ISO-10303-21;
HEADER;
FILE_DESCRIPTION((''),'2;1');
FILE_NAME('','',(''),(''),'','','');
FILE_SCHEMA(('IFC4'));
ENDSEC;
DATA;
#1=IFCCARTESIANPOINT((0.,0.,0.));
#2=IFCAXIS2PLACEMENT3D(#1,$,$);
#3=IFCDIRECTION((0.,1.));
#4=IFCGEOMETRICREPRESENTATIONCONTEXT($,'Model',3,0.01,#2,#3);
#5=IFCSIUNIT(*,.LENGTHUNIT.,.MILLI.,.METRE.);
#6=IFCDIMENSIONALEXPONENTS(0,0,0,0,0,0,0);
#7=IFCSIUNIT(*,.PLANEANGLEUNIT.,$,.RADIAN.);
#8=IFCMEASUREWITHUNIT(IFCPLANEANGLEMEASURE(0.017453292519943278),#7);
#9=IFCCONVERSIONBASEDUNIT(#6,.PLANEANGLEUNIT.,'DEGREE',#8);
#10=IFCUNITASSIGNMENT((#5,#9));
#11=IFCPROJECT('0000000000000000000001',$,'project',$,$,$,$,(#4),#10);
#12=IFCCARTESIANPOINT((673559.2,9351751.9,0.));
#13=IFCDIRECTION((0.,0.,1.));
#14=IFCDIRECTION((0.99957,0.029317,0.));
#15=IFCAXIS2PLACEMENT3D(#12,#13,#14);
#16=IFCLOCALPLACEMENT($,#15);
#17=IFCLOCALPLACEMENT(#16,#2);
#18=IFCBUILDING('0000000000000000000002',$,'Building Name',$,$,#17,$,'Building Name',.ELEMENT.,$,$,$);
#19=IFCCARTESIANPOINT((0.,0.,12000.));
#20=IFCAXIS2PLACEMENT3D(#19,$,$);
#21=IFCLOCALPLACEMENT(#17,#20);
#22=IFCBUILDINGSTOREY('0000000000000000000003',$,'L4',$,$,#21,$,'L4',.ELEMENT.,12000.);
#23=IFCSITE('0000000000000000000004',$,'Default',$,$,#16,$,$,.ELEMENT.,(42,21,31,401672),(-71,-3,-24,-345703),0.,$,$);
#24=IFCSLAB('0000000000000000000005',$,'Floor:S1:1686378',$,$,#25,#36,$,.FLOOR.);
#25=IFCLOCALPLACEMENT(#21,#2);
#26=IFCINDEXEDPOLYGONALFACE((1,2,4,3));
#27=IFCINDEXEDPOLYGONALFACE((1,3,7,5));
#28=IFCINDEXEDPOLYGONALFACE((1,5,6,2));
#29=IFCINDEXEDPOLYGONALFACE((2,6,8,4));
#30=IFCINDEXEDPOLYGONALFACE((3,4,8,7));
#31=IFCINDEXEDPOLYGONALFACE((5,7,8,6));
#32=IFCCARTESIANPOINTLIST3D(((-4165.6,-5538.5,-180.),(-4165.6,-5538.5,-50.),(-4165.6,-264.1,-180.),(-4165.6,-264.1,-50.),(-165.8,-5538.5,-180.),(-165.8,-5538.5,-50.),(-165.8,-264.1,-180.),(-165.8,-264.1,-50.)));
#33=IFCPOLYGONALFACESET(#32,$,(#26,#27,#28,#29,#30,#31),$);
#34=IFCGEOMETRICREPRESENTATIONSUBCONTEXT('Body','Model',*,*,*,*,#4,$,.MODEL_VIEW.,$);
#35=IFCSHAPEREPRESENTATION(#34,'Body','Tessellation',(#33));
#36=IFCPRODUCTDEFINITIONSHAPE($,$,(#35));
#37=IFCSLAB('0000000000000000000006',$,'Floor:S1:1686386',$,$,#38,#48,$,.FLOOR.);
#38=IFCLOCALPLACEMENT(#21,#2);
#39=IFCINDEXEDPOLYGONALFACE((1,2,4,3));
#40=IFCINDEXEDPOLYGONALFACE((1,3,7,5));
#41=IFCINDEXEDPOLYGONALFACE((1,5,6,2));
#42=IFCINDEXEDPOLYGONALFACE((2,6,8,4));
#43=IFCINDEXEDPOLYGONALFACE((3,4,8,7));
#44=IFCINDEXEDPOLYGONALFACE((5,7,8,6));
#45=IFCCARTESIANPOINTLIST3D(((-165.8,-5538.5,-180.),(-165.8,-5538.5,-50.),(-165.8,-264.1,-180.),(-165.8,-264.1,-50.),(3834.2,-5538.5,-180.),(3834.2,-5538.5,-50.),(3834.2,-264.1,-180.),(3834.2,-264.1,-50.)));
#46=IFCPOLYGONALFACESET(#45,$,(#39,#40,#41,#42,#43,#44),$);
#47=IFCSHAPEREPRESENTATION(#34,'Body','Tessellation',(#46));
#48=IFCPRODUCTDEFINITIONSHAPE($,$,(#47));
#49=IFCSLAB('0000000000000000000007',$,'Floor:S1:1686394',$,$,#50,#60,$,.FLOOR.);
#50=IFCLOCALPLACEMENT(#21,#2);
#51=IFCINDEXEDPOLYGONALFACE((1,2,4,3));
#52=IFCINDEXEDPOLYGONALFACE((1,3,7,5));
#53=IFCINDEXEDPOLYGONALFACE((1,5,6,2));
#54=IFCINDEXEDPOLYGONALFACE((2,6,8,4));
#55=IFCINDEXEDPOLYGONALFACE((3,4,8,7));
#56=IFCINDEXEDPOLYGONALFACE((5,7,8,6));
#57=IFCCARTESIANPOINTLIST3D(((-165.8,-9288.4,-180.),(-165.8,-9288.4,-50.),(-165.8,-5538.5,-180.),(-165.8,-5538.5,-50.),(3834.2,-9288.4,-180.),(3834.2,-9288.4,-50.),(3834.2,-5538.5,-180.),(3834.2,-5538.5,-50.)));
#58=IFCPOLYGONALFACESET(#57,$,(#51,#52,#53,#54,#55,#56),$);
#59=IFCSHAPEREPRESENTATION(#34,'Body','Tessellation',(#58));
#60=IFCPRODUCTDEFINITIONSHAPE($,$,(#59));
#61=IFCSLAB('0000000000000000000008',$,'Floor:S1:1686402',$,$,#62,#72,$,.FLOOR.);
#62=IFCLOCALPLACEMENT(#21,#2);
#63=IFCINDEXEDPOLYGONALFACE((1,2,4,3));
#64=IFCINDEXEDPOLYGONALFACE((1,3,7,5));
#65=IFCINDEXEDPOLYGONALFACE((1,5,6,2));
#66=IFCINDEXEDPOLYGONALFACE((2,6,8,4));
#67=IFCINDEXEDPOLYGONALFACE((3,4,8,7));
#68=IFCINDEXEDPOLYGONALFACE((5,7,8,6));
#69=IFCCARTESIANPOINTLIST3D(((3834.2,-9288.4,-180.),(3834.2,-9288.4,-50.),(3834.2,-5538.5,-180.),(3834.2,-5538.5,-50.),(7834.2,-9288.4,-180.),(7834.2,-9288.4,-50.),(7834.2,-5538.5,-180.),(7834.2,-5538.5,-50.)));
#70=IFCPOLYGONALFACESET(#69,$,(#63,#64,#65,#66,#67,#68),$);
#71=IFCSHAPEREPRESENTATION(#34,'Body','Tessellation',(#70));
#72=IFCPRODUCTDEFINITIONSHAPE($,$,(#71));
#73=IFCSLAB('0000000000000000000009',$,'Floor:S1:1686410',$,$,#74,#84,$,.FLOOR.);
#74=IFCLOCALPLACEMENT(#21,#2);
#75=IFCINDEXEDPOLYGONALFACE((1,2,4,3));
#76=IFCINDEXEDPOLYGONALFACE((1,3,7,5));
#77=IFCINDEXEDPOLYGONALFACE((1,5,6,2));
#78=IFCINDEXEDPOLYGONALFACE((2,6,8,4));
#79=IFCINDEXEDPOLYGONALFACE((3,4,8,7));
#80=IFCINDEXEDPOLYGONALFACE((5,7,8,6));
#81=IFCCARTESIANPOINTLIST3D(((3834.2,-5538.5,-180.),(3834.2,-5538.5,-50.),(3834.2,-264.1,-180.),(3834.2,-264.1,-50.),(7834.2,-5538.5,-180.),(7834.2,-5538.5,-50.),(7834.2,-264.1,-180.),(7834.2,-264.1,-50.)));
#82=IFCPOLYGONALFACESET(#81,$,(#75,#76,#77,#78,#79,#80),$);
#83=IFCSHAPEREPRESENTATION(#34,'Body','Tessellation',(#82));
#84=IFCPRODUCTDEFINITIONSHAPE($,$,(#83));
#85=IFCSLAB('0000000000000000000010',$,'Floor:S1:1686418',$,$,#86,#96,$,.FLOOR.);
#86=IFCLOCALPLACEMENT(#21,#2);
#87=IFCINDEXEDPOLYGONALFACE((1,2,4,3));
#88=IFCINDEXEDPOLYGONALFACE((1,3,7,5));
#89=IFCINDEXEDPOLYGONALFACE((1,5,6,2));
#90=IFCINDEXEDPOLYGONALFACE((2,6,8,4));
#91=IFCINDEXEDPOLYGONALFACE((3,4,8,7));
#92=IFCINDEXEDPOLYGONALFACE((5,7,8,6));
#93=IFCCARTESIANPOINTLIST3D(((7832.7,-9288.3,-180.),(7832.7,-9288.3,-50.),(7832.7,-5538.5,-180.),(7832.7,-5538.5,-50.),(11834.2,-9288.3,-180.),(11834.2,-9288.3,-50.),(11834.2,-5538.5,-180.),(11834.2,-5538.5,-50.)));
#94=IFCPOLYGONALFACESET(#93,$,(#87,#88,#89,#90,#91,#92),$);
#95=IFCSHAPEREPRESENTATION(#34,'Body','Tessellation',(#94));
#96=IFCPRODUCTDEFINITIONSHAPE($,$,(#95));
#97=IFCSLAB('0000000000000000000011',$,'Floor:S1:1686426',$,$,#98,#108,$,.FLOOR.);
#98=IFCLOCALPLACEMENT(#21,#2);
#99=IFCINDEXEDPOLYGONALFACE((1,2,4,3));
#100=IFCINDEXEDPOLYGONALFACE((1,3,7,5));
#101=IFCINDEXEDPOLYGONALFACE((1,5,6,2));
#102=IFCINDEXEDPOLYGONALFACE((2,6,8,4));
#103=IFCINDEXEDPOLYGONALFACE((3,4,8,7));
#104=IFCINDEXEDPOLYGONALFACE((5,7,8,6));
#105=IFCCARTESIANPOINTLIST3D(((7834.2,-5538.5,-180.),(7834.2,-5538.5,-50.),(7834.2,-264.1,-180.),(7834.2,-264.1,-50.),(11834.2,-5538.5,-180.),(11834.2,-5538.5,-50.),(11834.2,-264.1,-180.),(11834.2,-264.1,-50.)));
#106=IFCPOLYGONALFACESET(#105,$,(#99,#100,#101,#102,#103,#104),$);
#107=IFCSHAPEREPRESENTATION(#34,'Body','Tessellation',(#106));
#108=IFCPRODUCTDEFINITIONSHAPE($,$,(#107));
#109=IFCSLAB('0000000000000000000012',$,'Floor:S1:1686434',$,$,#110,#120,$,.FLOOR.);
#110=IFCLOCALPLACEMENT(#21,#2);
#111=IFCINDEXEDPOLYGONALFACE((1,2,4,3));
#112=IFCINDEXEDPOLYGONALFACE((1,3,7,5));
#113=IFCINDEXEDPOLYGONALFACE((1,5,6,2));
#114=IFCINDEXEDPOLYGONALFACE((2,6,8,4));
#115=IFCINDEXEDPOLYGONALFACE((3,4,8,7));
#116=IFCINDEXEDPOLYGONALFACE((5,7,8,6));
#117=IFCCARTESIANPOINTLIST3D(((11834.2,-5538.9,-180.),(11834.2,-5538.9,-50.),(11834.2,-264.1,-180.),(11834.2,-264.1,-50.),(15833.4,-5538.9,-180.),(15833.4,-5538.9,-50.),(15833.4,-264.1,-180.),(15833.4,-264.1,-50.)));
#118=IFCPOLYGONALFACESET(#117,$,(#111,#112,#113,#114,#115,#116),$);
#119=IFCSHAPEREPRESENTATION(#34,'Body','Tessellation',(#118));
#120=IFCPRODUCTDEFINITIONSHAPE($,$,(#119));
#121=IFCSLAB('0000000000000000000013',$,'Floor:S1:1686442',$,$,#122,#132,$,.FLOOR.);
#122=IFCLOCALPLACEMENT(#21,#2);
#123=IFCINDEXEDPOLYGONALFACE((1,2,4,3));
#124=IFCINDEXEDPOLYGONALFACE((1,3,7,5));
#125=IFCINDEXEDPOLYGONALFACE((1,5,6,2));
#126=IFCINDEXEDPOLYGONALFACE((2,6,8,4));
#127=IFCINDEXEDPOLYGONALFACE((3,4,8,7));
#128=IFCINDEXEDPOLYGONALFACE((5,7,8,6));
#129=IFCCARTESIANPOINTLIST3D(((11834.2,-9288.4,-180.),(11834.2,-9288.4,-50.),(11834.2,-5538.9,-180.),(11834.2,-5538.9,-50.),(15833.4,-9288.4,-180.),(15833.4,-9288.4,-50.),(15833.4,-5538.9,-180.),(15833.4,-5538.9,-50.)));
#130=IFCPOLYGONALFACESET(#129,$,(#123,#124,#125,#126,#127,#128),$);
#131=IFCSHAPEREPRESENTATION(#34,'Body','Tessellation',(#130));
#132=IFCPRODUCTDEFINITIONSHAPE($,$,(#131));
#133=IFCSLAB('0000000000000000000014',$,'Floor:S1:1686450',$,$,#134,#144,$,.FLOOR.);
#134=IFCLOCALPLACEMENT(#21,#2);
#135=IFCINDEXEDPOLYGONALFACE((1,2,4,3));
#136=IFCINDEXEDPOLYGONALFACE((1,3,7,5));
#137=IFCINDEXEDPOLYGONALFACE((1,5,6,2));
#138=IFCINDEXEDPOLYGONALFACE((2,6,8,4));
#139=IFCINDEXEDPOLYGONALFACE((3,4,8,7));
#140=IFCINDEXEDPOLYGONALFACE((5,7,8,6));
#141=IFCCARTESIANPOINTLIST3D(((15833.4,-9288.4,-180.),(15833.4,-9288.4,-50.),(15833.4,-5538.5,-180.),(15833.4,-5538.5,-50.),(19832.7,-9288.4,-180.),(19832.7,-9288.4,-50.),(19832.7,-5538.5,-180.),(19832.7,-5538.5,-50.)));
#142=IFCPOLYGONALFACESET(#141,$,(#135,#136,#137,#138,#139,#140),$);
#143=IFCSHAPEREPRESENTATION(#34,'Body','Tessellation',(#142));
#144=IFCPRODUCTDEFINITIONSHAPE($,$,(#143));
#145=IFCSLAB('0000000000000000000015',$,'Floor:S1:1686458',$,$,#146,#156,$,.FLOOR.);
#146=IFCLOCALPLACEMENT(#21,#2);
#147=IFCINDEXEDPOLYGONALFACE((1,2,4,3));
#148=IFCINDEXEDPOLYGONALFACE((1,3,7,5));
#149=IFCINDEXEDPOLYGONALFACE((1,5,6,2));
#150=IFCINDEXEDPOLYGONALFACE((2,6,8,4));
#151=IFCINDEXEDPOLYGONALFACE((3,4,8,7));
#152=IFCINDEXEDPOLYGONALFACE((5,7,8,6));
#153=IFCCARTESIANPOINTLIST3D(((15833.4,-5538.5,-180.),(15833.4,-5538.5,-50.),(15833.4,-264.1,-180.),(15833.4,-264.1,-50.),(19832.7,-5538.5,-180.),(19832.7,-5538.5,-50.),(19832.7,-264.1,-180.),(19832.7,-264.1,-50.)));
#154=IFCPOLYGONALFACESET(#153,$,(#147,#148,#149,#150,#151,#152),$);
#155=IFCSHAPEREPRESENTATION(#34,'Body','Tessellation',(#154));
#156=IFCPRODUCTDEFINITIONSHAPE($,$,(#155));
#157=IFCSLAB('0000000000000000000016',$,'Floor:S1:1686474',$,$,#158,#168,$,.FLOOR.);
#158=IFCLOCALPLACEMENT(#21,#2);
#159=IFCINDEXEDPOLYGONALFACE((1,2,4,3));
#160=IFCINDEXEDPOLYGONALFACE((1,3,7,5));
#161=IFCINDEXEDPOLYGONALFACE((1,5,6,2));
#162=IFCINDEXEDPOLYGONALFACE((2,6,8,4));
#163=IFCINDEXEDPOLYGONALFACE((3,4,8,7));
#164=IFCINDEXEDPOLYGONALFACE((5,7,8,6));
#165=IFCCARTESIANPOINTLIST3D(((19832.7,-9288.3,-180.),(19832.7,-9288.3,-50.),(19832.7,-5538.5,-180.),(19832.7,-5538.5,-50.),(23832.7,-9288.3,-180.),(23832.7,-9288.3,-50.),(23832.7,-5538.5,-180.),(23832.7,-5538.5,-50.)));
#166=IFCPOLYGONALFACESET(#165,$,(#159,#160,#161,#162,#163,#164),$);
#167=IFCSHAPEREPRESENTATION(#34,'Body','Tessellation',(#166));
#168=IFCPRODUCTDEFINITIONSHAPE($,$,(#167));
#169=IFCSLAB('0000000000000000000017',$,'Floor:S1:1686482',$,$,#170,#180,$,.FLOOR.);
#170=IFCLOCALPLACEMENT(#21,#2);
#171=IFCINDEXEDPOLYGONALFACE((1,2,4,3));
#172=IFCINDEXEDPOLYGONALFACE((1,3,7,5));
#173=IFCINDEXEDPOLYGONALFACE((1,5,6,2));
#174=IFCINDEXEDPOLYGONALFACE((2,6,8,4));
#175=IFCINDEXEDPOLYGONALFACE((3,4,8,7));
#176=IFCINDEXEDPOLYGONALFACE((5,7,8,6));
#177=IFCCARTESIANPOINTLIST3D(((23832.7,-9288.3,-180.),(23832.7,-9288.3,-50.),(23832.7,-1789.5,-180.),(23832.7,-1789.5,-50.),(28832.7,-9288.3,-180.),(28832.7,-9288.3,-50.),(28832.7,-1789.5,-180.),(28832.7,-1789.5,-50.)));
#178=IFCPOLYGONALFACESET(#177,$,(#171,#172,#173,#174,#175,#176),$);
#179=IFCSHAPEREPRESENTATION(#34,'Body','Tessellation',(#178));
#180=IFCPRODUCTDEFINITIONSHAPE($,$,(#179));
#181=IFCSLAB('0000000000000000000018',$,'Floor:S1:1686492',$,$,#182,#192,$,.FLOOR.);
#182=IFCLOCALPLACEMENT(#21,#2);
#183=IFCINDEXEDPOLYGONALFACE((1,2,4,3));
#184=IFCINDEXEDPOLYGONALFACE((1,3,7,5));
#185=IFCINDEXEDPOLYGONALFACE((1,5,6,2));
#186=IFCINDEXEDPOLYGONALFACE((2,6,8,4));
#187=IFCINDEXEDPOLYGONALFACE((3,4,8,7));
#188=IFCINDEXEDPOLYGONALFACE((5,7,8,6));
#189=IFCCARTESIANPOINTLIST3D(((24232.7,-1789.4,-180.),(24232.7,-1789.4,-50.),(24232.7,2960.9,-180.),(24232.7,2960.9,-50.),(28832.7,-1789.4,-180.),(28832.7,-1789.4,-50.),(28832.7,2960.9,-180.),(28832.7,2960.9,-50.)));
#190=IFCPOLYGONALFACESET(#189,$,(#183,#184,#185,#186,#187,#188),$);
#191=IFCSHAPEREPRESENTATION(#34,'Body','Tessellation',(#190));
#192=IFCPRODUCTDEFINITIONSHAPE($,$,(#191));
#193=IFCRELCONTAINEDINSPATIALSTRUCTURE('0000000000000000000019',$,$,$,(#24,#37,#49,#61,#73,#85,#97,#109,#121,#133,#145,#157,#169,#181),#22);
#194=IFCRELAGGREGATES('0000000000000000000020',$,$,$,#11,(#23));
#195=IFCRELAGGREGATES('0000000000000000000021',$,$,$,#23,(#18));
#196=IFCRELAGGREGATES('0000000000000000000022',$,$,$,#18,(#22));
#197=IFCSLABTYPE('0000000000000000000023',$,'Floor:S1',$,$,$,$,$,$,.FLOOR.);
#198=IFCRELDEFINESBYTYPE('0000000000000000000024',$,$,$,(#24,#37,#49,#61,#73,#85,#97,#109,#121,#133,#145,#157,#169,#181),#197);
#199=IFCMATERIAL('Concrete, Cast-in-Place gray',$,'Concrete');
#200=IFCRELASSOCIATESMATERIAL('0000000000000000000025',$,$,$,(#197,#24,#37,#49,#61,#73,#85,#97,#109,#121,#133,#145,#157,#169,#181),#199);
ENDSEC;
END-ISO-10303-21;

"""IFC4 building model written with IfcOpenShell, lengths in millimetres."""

from ifc_helpers import new_model, entity, si_unit, converted_unit, direction, frame, origin, place, context, subcontext, project, spatial, indexed_curve, outline, extrude, material, type_object, element, save


model = new_model("IFC4")

# Units and contexts
model_context = context("Model", 3, precision=0.01, world=origin(), true_north=direction((0.0, 1.0)))
body_context = subcontext(model_context, "Body", "Model", "MODEL_VIEW")
ifc_project = project(units=[si_unit("LENGTHUNIT", "METRE", prefix="MILLI"), converted_unit("PLANEANGLEUNIT", "DEGREE", entity("IfcPlaneAngleMeasure", 0.017453292519943278), si_unit("PLANEANGLEUNIT", "RADIAN"), dimensions=[0, 0, 0, 0, 0, 0, 0])], contexts=[model_context])

# Site, building, storey
site_placement = place(None, frame((673559.2, 9351751.9, 0.0), z_axis=(0.0, 0.0, 1.0), x_axis=(0.99957, 0.029317, 0.0)))
site = spatial("IfcSite", under=ifc_project, at=site_placement, Name="Default", CompositionType="ELEMENT", RefLatitude=(42, 21, 31, 401672), RefLongitude=(-71, -3, -24, -345703), RefElevation=0.0)
building_placement = place(site_placement, origin())
building = spatial("IfcBuilding", under=site, at=building_placement, Name="Building Name", LongName="Building Name", CompositionType="ELEMENT")
storey_placement = place(building_placement, frame((0.0, 0.0, 12000.0)))
storey = spatial("IfcBuildingStorey", under=building, at=storey_placement, Name="L4", LongName="L4", CompositionType="ELEMENT", Elevation=12000.0)

# Shared definitions
ifc_material_1 = material(Name="Concrete, Cast-in-Place gray", Category="Concrete")

# Slabs
slab_type_1 = type_object("IfcSlabType", Name="Floor:S1", PredefinedType="FLOOR", material=ifc_material_1)
slab_1_placement = place(storey_placement, origin())
element("IfcSlab", 1, at=slab_1_placement, inside=storey, type_object=slab_type_1, material=ifc_material_1, Name="Floor:S1:1686378", PredefinedType="FLOOR", context=body_context, shape_type="SweptSolid", body=[
    extrude(outline(indexed_curve([(-2637.2, -1999.9), (2637.2, -1999.9), (2637.2, 1999.9), (-2637.2, 1999.9), (-2637.2, -1999.9)], self_intersect=False)), frame((-2165.7, -2901.3, -50.0), z_axis=(0.0, 0.0, -1.0), x_axis=(0.0, 1.0, 0.0)), (0.0, 0.0, 1.0), 130.0),
])
slab_2_placement = place(storey_placement, origin())
element("IfcSlab", 2, at=slab_2_placement, inside=storey, type_object=slab_type_1, material=ifc_material_1, Name="Floor:S1:1686386", PredefinedType="FLOOR", context=body_context, shape_type="SweptSolid", body=[
    extrude(outline(indexed_curve([(-2637.2, -2000.0), (2637.2, -2000.0), (2637.2, 2000.0), (-2637.2, 2000.0), (-2637.2, -2000.0)], self_intersect=False)), frame((1834.2, -2901.3, -50.0), z_axis=(0.0, 0.0, -1.0), x_axis=(0.0, 1.0, 0.0)), (0.0, 0.0, 1.0), 130.0),
])
slab_3_placement = place(storey_placement, origin())
element("IfcSlab", 3, at=slab_3_placement, inside=storey, type_object=slab_type_1, material=ifc_material_1, Name="Floor:S1:1686394", PredefinedType="FLOOR", context=body_context, shape_type="SweptSolid", body=[
    extrude(outline(indexed_curve([(-1874.9, -2000.0), (1874.9, -2000.0), (1874.9, 2000.0), (-1874.9, 2000.0), (-1874.9, -2000.0)], self_intersect=False)), frame((1834.2, -7413.5, -50.0), z_axis=(0.0, 0.0, -1.0), x_axis=(0.0, 1.0, 0.0)), (0.0, 0.0, 1.0), 130.0),
])
slab_4_placement = place(storey_placement, origin())
element("IfcSlab", 4, at=slab_4_placement, inside=storey, type_object=slab_type_1, material=ifc_material_1, Name="Floor:S1:1686402", PredefinedType="FLOOR", context=body_context, shape_type="SweptSolid", body=[
    extrude(outline(indexed_curve([(-1874.9, -2000.0), (1874.9, -2000.0), (1874.9, 2000.0), (-1874.9, 2000.0), (-1874.9, -2000.0)], self_intersect=False)), frame((5834.2, -7413.5, -50.0), z_axis=(0.0, 0.0, -1.0), x_axis=(0.0, 1.0, 0.0)), (0.0, 0.0, 1.0), 130.0),
])
slab_5_placement = place(storey_placement, origin())
element("IfcSlab", 5, at=slab_5_placement, inside=storey, type_object=slab_type_1, material=ifc_material_1, Name="Floor:S1:1686410", PredefinedType="FLOOR", context=body_context, shape_type="SweptSolid", body=[
    extrude(outline(indexed_curve([(-2637.2, -2000.0), (2637.2, -2000.0), (2637.2, 2000.0), (-2637.2, 2000.0), (-2637.2, -2000.0)], self_intersect=False)), frame((5834.2, -2901.3, -50.0), z_axis=(0.0, 0.0, -1.0), x_axis=(0.0, 1.0, 0.0)), (0.0, 0.0, 1.0), 130.0),
])
slab_6_placement = place(storey_placement, origin())
element("IfcSlab", 6, at=slab_6_placement, inside=storey, type_object=slab_type_1, material=ifc_material_1, Name="Floor:S1:1686418", PredefinedType="FLOOR", context=body_context, shape_type="SweptSolid", body=[
    extrude(outline(indexed_curve([(-1874.9, -2000.7), (1874.9, -2000.7), (1874.9, 2000.7), (-1874.9, 2000.7), (-1874.9, -2000.7)], self_intersect=False)), frame((9833.4, -7413.4, -50.0), z_axis=(0.0, 0.0, -1.0), x_axis=(0.0, 1.0, 0.0)), (0.0, 0.0, 1.0), 130.0),
])
slab_7_placement = place(storey_placement, origin())
element("IfcSlab", 7, at=slab_7_placement, inside=storey, type_object=slab_type_1, material=ifc_material_1, Name="Floor:S1:1686426", PredefinedType="FLOOR", context=body_context, shape_type="SweptSolid", body=[
    extrude(outline(indexed_curve([(-2637.2, -2000.0), (2637.2, -2000.0), (2637.2, 2000.0), (-2637.2, 2000.0), (-2637.2, -2000.0)], self_intersect=False)), frame((9834.2, -2901.3, -50.0), z_axis=(0.0, 0.0, -1.0), x_axis=(0.0, 1.0, 0.0)), (0.0, 0.0, 1.0), 130.0),
])
slab_8_placement = place(storey_placement, origin())
element("IfcSlab", 8, at=slab_8_placement, inside=storey, type_object=slab_type_1, material=ifc_material_1, Name="Floor:S1:1686434", PredefinedType="FLOOR", context=body_context, shape_type="SweptSolid", body=[
    extrude(outline(indexed_curve([(-2637.4, -1999.6), (2637.4, -1999.6), (2637.4, 1999.6), (-2637.4, 1999.6), (-2637.4, -1999.6)], self_intersect=False)), frame((13833.8, -2901.5, -50.0), z_axis=(0.0, 0.0, -1.0), x_axis=(0.0, 1.0, 0.0)), (0.0, 0.0, 1.0), 130.0),
])
slab_9_placement = place(storey_placement, origin())
element("IfcSlab", 9, at=slab_9_placement, inside=storey, type_object=slab_type_1, material=ifc_material_1, Name="Floor:S1:1686442", PredefinedType="FLOOR", context=body_context, shape_type="SweptSolid", body=[
    extrude(outline(indexed_curve([(-1874.7, -1999.6), (1874.7, -1999.6), (1874.7, 1999.6), (-1874.7, 1999.6), (-1874.7, -1999.6)], self_intersect=False)), frame((13833.8, -7413.6, -50.0), z_axis=(0.0, 0.0, -1.0), x_axis=(0.0, 1.0, 0.0)), (0.0, 0.0, 1.0), 130.0),
])
slab_10_placement = place(storey_placement, origin())
element("IfcSlab", 10, at=slab_10_placement, inside=storey, type_object=slab_type_1, material=ifc_material_1, Name="Floor:S1:1686450", PredefinedType="FLOOR", context=body_context, shape_type="SweptSolid", body=[
    extrude(outline(indexed_curve([(-1874.9, -1999.6), (1874.9, -1999.6), (1874.9, 1999.6), (-1874.9, 1999.6), (-1874.9, -1999.6)], self_intersect=False)), frame((17833.0, -7413.5, -50.0), z_axis=(0.0, 0.0, -1.0), x_axis=(0.0, 1.0, 0.0)), (0.0, 0.0, 1.0), 130.0),
])
slab_11_placement = place(storey_placement, origin())
element("IfcSlab", 11, at=slab_11_placement, inside=storey, type_object=slab_type_1, material=ifc_material_1, Name="Floor:S1:1686458", PredefinedType="FLOOR", context=body_context, shape_type="SweptSolid", body=[
    extrude(outline(indexed_curve([(-2637.2, -1999.6), (2637.2, -1999.6), (2637.2, 1999.6), (-2637.2, 1999.6), (-2637.2, -1999.6)], self_intersect=False)), frame((17833.0, -2901.3, -50.0), z_axis=(0.0, 0.0, -1.0), x_axis=(0.0, 1.0, 0.0)), (0.0, 0.0, 1.0), 130.0),
])
slab_12_placement = place(storey_placement, origin())
element("IfcSlab", 12, at=slab_12_placement, inside=storey, type_object=slab_type_1, material=ifc_material_1, Name="Floor:S1:1686474", PredefinedType="FLOOR", context=body_context, shape_type="SweptSolid", body=[
    extrude(outline(indexed_curve([(-1874.9, -2000.0), (1874.9, -2000.0), (1874.9, 2000.0), (-1874.9, 2000.0), (-1874.9, -2000.0)], self_intersect=False)), frame((21832.7, -7413.4, -50.0), z_axis=(0.0, 0.0, -1.0), x_axis=(0.0, 1.0, 0.0)), (0.0, 0.0, 1.0), 130.0),
])
slab_13_placement = place(storey_placement, origin())
element("IfcSlab", 13, at=slab_13_placement, inside=storey, type_object=slab_type_1, material=ifc_material_1, Name="Floor:S1:1686482", PredefinedType="FLOOR", context=body_context, shape_type="SweptSolid", body=[
    extrude(outline(indexed_curve([(-3749.4, -2500.0), (3749.4, -2500.0), (3749.4, 2500.0), (-3749.4, 2500.0), (-3749.4, -2500.0)], self_intersect=False)), frame((26332.7, -5538.9, -50.0), z_axis=(0.0, 0.0, -1.0), x_axis=(0.0, 1.0, 0.0)), (0.0, 0.0, 1.0), 130.0),
])
slab_14_placement = place(storey_placement, origin())
element("IfcSlab", 14, at=slab_14_placement, inside=storey, type_object=slab_type_1, material=ifc_material_1, Name="Floor:S1:1686492", PredefinedType="FLOOR", context=body_context, shape_type="SweptSolid", body=[
    extrude(outline(indexed_curve([(-2375.2, -2300.0), (2375.2, -2300.0), (2375.2, 2300.0), (-2375.2, 2300.0), (-2375.2, -2300.0)], self_intersect=False)), frame((26532.7, 585.8, -50.0), z_axis=(0.0, 0.0, -1.0), x_axis=(0.0, 1.0, 0.0)), (0.0, 0.0, 1.0), 130.0),
])

save(model, "model.ifc")
